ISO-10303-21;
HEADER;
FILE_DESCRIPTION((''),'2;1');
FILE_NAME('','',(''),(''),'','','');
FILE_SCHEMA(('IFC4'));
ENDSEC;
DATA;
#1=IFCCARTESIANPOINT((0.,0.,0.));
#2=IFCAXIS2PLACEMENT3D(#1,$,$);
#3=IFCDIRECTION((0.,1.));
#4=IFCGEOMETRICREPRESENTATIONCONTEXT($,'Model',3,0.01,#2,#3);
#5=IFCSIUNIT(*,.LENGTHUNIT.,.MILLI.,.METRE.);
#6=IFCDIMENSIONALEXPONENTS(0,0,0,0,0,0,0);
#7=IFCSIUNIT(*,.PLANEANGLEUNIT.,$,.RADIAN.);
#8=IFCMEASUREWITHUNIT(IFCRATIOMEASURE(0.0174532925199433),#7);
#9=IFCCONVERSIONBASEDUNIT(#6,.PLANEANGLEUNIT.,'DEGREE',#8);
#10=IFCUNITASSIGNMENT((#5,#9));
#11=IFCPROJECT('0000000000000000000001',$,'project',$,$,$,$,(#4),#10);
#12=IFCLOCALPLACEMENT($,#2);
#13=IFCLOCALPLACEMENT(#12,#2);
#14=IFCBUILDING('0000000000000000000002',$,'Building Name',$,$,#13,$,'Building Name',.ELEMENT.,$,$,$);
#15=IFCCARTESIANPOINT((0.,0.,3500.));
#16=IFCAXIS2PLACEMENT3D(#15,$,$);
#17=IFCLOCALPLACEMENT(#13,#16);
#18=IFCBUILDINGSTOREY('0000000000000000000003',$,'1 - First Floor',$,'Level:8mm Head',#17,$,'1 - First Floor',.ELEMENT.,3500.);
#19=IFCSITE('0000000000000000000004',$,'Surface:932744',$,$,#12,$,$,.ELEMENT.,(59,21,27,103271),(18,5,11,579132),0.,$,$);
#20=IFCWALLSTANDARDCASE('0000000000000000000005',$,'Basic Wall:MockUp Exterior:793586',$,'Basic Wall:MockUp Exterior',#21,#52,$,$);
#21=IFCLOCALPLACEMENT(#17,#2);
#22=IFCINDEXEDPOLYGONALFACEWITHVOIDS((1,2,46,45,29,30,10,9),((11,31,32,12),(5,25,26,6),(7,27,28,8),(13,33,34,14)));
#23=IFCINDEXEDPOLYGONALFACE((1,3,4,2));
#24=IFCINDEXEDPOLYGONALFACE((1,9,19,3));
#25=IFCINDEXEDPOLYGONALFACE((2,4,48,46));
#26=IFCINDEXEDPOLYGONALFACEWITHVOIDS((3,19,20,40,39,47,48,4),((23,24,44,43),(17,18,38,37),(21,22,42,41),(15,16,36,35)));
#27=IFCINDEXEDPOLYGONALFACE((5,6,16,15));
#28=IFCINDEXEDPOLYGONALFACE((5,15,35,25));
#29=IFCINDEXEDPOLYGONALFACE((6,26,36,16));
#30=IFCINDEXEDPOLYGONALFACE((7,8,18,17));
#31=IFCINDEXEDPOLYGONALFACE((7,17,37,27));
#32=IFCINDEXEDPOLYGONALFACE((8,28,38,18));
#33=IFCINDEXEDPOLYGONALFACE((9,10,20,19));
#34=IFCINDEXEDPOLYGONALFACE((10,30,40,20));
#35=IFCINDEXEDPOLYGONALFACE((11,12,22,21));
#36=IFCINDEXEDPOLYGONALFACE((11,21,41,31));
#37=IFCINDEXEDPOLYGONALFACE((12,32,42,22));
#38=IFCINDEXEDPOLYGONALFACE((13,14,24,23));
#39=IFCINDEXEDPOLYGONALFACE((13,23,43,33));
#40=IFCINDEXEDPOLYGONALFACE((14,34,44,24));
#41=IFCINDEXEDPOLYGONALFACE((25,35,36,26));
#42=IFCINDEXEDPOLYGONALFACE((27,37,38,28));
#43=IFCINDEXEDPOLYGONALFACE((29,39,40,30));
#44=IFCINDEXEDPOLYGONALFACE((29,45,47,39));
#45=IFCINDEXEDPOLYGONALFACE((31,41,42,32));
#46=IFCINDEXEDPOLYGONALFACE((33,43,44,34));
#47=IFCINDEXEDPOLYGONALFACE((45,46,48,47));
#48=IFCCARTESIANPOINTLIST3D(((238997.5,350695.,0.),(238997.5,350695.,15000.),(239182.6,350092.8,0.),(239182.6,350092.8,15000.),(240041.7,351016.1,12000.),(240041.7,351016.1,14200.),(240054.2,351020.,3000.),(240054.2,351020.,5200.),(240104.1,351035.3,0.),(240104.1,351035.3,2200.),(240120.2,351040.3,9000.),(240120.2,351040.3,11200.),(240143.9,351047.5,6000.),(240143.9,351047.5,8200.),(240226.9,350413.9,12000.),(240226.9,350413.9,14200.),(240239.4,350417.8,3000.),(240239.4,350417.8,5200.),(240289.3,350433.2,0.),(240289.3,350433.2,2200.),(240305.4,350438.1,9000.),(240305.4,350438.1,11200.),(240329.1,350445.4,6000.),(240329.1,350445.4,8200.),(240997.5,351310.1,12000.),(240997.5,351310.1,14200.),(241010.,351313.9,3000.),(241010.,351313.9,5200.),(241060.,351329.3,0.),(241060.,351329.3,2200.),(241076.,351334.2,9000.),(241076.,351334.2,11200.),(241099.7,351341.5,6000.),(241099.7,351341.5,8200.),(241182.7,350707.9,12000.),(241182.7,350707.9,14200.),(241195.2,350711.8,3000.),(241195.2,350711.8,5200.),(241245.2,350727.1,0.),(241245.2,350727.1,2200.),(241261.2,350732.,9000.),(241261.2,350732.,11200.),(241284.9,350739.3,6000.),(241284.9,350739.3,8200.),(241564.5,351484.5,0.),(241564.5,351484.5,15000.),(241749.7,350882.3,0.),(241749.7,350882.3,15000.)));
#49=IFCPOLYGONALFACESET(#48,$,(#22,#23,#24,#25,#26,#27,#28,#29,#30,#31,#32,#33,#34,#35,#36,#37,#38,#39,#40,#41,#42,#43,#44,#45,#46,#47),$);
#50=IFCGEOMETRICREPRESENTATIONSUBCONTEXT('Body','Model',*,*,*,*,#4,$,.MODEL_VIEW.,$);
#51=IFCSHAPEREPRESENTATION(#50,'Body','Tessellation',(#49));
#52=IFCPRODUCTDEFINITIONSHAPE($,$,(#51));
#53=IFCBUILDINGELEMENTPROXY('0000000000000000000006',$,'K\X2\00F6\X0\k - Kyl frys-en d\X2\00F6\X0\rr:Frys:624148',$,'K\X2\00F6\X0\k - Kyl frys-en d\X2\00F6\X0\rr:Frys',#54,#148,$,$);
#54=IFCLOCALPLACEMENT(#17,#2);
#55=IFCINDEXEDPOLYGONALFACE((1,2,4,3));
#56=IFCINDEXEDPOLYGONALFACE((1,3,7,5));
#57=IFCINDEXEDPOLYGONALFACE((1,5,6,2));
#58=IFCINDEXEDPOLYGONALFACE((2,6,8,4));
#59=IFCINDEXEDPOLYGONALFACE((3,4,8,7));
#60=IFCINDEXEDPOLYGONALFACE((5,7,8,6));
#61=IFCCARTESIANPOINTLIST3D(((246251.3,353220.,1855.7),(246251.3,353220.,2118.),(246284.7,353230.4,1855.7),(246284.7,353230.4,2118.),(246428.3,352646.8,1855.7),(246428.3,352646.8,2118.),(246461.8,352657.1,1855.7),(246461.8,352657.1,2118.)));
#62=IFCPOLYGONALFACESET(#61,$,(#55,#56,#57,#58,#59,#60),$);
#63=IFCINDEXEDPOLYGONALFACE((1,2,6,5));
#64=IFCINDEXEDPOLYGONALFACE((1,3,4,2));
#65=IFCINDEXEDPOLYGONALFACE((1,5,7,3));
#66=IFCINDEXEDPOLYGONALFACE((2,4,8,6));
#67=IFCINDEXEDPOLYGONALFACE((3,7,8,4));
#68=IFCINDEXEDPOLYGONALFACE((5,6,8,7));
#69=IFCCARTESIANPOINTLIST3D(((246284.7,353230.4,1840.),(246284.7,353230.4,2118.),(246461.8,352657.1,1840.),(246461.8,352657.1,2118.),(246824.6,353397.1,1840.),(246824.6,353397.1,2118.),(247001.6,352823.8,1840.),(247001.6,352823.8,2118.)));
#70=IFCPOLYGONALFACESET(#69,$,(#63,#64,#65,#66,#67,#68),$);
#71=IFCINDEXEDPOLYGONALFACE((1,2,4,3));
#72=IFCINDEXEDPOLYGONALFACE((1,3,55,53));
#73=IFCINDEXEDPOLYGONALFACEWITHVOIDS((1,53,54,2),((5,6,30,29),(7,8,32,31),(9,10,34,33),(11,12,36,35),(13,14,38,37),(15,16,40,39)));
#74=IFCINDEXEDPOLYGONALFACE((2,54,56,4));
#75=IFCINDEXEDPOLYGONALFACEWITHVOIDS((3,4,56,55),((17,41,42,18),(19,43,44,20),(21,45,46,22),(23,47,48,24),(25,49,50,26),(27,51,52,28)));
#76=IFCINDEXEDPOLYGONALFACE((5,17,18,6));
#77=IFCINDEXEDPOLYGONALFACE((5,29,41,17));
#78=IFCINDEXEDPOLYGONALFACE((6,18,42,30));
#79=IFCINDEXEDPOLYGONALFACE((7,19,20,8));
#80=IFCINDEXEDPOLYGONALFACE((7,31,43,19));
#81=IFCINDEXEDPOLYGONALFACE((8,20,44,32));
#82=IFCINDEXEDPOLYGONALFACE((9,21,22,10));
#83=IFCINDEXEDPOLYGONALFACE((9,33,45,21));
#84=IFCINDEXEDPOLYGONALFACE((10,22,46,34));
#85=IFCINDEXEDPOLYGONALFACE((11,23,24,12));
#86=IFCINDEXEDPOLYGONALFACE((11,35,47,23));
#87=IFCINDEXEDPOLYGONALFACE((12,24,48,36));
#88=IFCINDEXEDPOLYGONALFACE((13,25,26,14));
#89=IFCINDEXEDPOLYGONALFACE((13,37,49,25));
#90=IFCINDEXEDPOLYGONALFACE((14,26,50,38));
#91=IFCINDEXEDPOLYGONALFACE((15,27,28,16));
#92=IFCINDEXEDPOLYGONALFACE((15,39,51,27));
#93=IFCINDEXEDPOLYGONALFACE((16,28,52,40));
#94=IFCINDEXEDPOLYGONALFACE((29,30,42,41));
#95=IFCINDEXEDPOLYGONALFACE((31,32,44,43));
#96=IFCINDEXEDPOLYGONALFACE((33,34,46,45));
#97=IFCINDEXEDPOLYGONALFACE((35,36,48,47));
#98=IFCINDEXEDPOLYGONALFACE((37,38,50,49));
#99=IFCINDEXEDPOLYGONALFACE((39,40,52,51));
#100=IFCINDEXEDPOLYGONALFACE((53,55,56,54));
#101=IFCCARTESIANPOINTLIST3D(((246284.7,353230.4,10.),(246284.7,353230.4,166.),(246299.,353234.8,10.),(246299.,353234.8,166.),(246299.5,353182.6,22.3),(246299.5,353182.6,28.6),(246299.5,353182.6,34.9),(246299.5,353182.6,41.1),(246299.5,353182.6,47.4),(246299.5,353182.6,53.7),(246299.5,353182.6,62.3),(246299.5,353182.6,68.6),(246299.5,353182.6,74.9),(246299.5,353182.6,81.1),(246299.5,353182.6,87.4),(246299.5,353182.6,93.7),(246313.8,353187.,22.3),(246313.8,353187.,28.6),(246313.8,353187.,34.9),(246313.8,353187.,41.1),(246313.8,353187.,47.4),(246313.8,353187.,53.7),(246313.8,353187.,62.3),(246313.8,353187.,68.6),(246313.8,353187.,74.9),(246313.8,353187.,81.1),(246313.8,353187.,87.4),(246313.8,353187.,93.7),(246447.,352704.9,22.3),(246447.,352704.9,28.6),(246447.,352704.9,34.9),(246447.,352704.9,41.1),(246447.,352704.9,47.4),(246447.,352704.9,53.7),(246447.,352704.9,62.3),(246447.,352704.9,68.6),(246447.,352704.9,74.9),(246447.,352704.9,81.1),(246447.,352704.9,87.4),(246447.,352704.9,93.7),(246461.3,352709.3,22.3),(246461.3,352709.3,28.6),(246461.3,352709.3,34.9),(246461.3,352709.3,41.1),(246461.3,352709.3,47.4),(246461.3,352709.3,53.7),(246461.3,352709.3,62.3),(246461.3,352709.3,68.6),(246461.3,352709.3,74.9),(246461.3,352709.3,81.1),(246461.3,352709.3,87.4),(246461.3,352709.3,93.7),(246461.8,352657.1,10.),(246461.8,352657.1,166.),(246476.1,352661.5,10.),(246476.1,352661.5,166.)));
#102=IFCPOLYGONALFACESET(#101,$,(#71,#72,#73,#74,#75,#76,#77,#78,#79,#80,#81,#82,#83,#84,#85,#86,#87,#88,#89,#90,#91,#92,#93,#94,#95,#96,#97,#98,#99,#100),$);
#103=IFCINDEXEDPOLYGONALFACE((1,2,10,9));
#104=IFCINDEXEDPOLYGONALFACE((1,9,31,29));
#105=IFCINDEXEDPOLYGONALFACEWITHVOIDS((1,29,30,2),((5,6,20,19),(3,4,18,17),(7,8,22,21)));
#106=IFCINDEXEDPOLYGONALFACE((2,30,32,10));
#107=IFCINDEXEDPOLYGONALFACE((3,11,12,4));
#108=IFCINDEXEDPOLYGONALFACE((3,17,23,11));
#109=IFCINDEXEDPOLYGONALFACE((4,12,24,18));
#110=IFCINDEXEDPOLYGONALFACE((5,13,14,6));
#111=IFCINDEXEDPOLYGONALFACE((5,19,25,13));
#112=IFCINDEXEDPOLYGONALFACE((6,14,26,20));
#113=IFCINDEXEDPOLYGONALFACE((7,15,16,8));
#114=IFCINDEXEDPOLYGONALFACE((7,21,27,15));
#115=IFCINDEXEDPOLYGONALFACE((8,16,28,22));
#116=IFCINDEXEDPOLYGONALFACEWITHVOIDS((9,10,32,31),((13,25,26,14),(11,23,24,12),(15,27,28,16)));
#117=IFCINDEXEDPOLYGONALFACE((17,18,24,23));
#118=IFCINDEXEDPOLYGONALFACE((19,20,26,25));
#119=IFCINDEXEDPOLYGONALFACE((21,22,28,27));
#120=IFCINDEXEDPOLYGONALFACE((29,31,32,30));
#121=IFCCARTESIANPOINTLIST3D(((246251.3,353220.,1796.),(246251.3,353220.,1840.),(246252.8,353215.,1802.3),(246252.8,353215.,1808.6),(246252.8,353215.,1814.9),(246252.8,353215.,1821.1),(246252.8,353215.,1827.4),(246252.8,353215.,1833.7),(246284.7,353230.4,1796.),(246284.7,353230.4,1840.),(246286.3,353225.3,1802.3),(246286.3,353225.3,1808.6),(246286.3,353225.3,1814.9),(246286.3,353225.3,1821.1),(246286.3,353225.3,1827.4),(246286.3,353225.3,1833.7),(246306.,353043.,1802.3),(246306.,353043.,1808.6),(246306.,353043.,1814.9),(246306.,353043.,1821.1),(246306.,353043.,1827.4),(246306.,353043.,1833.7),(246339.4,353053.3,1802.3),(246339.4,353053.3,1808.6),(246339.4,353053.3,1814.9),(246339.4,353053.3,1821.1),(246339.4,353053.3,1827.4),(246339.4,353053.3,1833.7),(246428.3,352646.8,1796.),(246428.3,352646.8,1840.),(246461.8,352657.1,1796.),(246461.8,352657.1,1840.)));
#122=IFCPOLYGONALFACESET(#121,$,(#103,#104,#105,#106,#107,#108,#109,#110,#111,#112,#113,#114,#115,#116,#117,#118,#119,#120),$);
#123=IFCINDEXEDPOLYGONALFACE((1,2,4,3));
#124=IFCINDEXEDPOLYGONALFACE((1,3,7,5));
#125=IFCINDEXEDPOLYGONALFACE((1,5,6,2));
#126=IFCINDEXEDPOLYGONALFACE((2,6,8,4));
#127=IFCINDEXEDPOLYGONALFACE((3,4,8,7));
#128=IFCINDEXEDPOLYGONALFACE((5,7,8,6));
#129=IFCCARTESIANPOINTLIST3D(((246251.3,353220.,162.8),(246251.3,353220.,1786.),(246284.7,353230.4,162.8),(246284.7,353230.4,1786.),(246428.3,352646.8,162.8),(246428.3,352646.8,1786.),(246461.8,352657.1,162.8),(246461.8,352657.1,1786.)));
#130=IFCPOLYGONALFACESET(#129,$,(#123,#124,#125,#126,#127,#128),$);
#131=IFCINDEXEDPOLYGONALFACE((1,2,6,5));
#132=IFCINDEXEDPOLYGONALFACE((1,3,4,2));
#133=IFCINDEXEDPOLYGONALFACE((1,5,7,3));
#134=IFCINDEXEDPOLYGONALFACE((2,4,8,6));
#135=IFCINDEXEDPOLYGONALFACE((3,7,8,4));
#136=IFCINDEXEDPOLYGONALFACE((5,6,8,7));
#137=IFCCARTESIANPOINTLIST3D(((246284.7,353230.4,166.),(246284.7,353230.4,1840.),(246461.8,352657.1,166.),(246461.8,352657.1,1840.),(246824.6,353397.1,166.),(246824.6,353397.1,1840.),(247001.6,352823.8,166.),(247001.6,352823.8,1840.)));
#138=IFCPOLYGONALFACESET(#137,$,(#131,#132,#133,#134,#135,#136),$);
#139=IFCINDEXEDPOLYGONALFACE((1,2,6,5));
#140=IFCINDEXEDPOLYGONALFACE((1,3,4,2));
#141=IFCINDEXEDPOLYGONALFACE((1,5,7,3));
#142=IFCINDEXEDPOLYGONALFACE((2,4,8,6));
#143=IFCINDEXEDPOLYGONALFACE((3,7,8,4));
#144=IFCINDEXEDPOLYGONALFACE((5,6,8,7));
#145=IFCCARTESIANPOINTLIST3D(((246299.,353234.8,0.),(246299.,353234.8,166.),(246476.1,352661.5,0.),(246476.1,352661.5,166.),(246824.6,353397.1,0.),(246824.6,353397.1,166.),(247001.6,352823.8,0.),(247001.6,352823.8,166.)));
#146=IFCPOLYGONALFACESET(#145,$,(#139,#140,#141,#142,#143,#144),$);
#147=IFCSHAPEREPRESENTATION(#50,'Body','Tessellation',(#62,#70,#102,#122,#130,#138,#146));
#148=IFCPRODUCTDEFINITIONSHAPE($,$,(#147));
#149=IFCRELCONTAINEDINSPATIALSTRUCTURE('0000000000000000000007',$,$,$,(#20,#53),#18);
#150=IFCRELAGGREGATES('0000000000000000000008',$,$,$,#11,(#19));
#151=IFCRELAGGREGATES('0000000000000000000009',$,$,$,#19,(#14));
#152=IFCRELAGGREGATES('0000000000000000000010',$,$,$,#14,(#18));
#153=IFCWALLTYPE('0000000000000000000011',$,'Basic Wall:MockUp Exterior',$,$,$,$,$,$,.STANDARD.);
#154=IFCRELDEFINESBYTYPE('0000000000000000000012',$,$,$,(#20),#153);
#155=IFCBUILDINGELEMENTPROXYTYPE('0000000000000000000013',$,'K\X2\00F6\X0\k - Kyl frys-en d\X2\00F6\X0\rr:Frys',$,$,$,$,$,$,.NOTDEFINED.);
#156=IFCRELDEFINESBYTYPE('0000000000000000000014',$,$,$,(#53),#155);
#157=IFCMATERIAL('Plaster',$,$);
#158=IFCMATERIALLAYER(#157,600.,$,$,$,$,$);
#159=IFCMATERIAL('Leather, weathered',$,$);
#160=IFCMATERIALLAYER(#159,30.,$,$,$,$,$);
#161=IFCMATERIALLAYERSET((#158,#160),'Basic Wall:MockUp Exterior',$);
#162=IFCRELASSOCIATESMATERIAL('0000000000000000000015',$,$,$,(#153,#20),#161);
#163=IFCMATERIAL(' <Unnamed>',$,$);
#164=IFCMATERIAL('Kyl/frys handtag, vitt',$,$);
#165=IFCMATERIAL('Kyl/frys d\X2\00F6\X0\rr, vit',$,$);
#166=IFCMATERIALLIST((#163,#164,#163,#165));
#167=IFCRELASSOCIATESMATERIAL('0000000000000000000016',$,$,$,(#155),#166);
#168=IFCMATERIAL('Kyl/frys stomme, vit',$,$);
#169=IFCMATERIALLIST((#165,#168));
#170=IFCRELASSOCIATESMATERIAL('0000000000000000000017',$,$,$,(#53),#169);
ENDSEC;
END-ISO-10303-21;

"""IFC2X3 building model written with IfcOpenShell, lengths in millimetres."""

from ifc_helpers import new_model, entity, si_unit, converted_unit, direction, frame, frame_2d, origin, origin_2d_with_axis, place, context, subcontext, project, spatial, polyline, rectangle, outline, extrude, source, transform, mapped, material, material_list, layer, layer_set, layer_usage, type_object, type_shapes, element, save


model = new_model("IFC2X3")

# Units and contexts
model_context = context("Model", 3, precision=0.01, world=origin(), true_north=direction((0.0, 1.0)))
body_context = subcontext(model_context, "Body", "Model", "MODEL_VIEW")
ifc_project = project(units=[si_unit("LENGTHUNIT", "METRE", prefix="MILLI"), converted_unit("PLANEANGLEUNIT", "DEGREE", entity("IfcRatioMeasure", 0.0174532925199433), si_unit("PLANEANGLEUNIT", "RADIAN"), dimensions=[0, 0, 0, 0, 0, 0, 0])], contexts=[model_context])

# Site, building, storey
site_placement = place(None, origin())
site = spatial("IfcSite", under=ifc_project, at=site_placement, Name="Surface:932744", CompositionType="ELEMENT", RefLatitude=(59, 21, 27, 103271), RefLongitude=(18, 5, 11, 579132), RefElevation=0.0)
building_placement = place(site_placement, origin())
building = spatial("IfcBuilding", under=site, at=building_placement, Name="Building Name", LongName="Building Name", CompositionType="ELEMENT")
storey_placement = place(building_placement, frame((0.0, 0.0, 3500.0)))
storey = spatial("IfcBuildingStorey", under=building, at=storey_placement, Name="1 - First Floor", ObjectType="Level:8mm Head", LongName="1 - First Floor", CompositionType="ELEMENT", Elevation=3500.0)

# Shared definitions
ifc_material_1 = material(Name="Leather, weathered")

# Wall, openings
ifc_material_2 = material(Name="Plaster")
ifc_layer_1 = layer(ifc_material_2, 600.0)
ifc_layer_2 = layer(ifc_material_1, 30.0)
ifc_layer_set_1 = layer_set([ifc_layer_1, ifc_layer_2], Name="Basic Wall:MockUp Exterior")
ifc_layer_usage_1 = layer_usage(ifc_layer_set_1, "AXIS2", "NEGATIVE", 315.0)
wall_type_1 = type_object("IfcWallType", Name="Basic Wall:MockUp Exterior", PredefinedType="STANDARD", material=ifc_layer_set_1)
wall_1_placement = place(storey_placement, frame((241657.1, 351183.4, 0.0), z_axis=(0.0, 0.0, 1.0), x_axis=(-0.955818, -0.293958, 0.0)))
wall_1 = element("IfcWallStandardCase", 1, at=wall_1_placement, inside=storey, type_object=wall_type_1, material=ifc_layer_usage_1, Name="Basic Wall:MockUp Exterior:793586", ObjectType="Basic Wall:MockUp Exterior", context=body_context, shape_type="SweptSolid", body=[
    extrude(rectangle(XDim=2685.7, YDim=630.0, at=frame_2d((1342.9, 0.0), x_axis=(-1.0, 0.0))), origin(), (0.0, 0.0, 1.0), 15000.0),
])
opening_1_placement = place(wall_1_placement, frame((1527.9, 315.0, 0.0)))
element("IfcOpeningElement", 2, at=opening_1_placement, cuts=wall_1, ObjectType="Opening", context=body_context, shape_type="SweptSolid", body=[
    extrude(rectangle(XDim=2200.0, YDim=1000.0, at=frame_2d((1100.0, 500.0), x_axis=(1.0, 0.0))), frame((0.0, 0.0, 0.0), z_axis=(0.0, -1.0, 0.0), x_axis=(0.0, 0.0, 1.0)), (0.0, 0.0, 1.0), 630.0),
])
opening_2_placement = place(wall_1_placement, frame((1486.3, 315.0, 6000.0)))
element("IfcOpeningElement", 3, at=opening_2_placement, cuts=wall_1, ObjectType="Opening", context=body_context, shape_type="SweptSolid", body=[
    extrude(rectangle(XDim=2200.0, YDim=1000.0, at=frame_2d((1100.0, 500.0), x_axis=(1.0, 0.0))), frame((0.0, 0.0, 0.0), z_axis=(0.0, -1.0, 0.0), x_axis=(0.0, 0.0, 1.0)), (0.0, 0.0, 1.0), 630.0),
])
opening_3_placement = place(wall_1_placement, frame((1511.1, 315.0, 9000.0)))
element("IfcOpeningElement", 4, at=opening_3_placement, cuts=wall_1, ObjectType="Opening", context=body_context, shape_type="SweptSolid", body=[
    extrude(rectangle(XDim=2200.0, YDim=1000.0, at=frame_2d((1100.0, 500.0), x_axis=(1.0, 0.0))), frame((0.0, 0.0, 0.0), z_axis=(0.0, -1.0, 0.0), x_axis=(0.0, 0.0, 1.0)), (0.0, 0.0, 1.0), 630.0),
])
opening_4_placement = place(wall_1_placement, frame((1593.2, 315.0, 12000.0)))
element("IfcOpeningElement", 5, at=opening_4_placement, cuts=wall_1, ObjectType="Opening", context=body_context, shape_type="SweptSolid", body=[
    extrude(rectangle(XDim=2200.0, YDim=1000.0, at=frame_2d((1100.0, 500.0), x_axis=(1.0, 0.0))), frame((0.0, 0.0, 0.0), z_axis=(0.0, -1.0, 0.0), x_axis=(0.0, 0.0, 1.0)), (0.0, 0.0, 1.0), 630.0),
])
opening_5_placement = place(wall_1_placement, frame((1580.1, 315.0, 3000.0)))
element("IfcOpeningElement", 6, at=opening_5_placement, cuts=wall_1, ObjectType="Opening", context=body_context, shape_type="SweptSolid", body=[
    extrude(rectangle(XDim=2200.0, YDim=1000.0, at=frame_2d((1100.0, 500.0), x_axis=(1.0, 0.0))), frame((0.0, 0.0, 0.0), z_axis=(0.0, -1.0, 0.0), x_axis=(0.0, 0.0, 1.0)), (0.0, 0.0, 1.0), 630.0),
])

# Building element proxy
ifc_material_3 = material(Name="Kyl/frys dörr, vit")
ifc_material_4 = material(Name="Kyl/frys stomme, vit")
ifc_material_list_1 = material_list([ifc_material_3, ifc_material_4])
ifc_material_5 = material(Name=" <Unnamed>")
ifc_material_6 = material(Name="Kyl/frys handtag, vitt")
ifc_material_list_2 = material_list([ifc_material_5, ifc_material_6, ifc_material_5, ifc_material_3])
building_element_proxy_type_1 = type_object("IfcBuildingElementProxyType", Name="Kök - Kyl frys-en dörr:Frys", PredefinedType="NOTDEFINED", material=ifc_material_list_2)
shared_shape_1 = source(origin(), body_context, "Body", "SweptSolid", [
    extrude(rectangle(XDim=35.0, YDim=600.0, at=frame_2d((0.0, 0.0), x_axis=(1.0, 0.0))), frame((-254.6, 169.3, 1855.7), z_axis=(0.0, 0.0, 1.0), x_axis=(0.0, -1.0, 0.0)), (0.0, 0.0, 1.0), 262.3),
    extrude(rectangle(XDim=600.0, YDim=565.0, at=origin_2d_with_axis()), frame((-254.6, 469.3, 1840.0), z_axis=(0.0, 0.0, 1.0), x_axis=(-1.0, 0.0, 0.0)), (0.0, 0.0, 1.0), 278.0),
    extrude(outline(polyline([(-300.0, -78.0), (300.0, -78.0), (300.0, 78.0), (-300.0, 78.0), (-300.0, -78.0)]), holes=[polyline([(-250.0, 5.7), (250.0, 5.7), (250.0, -0.6), (-250.0, -0.6), (-250.0, 5.7)]), polyline([(-250.0, -6.9), (250.0, -6.9), (250.0, -13.1), (-250.0, -13.1), (-250.0, -6.9)]), polyline([(-250.0, -19.4), (250.0, -19.4), (250.0, -25.7), (-250.0, -25.7), (-250.0, -19.4)]), polyline([(-250.0, -34.3), (250.0, -34.3), (250.0, -40.6), (-250.0, -40.6), (-250.0, -34.3)]), polyline([(-250.0, -46.9), (250.0, -46.9), (250.0, -53.1), (-250.0, -53.1), (-250.0, -46.9)]), polyline([(-250.0, -59.4), (250.0, -59.4), (250.0, -65.7), (-250.0, -65.7), (-250.0, -59.4)])]), frame((-254.6, 186.8, 88.0), z_axis=(0.0, 1.0, 0.0), x_axis=(-1.0, 0.0, 0.0)), (0.0, 0.0, 1.0), 15.0),
    extrude(outline(polyline([(-300.0, -22.0), (300.0, -22.0), (300.0, 22.0), (-300.0, 22.0), (-300.0, -22.0)]), holes=[polyline([(114.7, 15.7), (294.7, 15.7), (294.7, 9.4), (114.7, 9.4), (114.7, 15.7)]), polyline([(114.7, 3.1), (294.7, 3.1), (294.7, -3.1), (114.7, -3.1), (114.7, 3.1)]), polyline([(114.7, -9.4), (294.7, -9.4), (294.7, -15.7), (114.7, -15.7), (114.7, -9.4)])]), frame((-254.6, 151.8, 1818.0), z_axis=(0.0, 1.0, 0.0), x_axis=(-1.0, 0.0, 0.0)), (0.0, 0.0, 1.0), 35.0),
    extrude(rectangle(XDim=35.0, YDim=600.0, at=frame_2d((0.0, 0.0), x_axis=(1.0, 0.0))), frame((-254.6, 169.3, 162.8), z_axis=(0.0, 0.0, 1.0), x_axis=(0.0, -1.0, 0.0)), (0.0, 0.0, 1.0), 1623.2),
    extrude(rectangle(XDim=600.0, YDim=565.0, at=frame_2d((0.0, 0.0), x_axis=(1.0, 0.0))), frame((-254.6, 469.3, 166.0), z_axis=(0.0, 0.0, 1.0), x_axis=(-1.0, 0.0, 0.0)), (0.0, 0.0, 1.0), 1674.0),
    extrude(rectangle(XDim=600.0, YDim=550.0, at=frame_2d((0.0, 0.0), x_axis=(1.0, 0.0))), frame((-254.6, 476.8, 0.0), z_axis=(0.0, 0.0, 1.0), x_axis=(-1.0, 0.0, 0.0)), (0.0, 0.0, 1.0), 166.0),
])
type_shapes(building_element_proxy_type_1, [shared_shape_1])
proxy_1_placement = place(storey_placement, frame((246269.9, 352645.3, 0.0), z_axis=(0.0, 0.0, 1.0), x_axis=(0.29508, -0.955473, 0.0)))
element("IfcBuildingElementProxy", 7, at=proxy_1_placement, inside=storey, type_object=building_element_proxy_type_1, material=ifc_material_list_1, Name="Kök - Kyl frys-en dörr:Frys:624148", ObjectType="Kök - Kyl frys-en dörr:Frys", context=body_context, shape_type="MappedRepresentation", body=[
    mapped(shared_shape_1, transform((0.0, 0.0, 0.0), scale=1.0)),
])

save(model, "model.ifc")
